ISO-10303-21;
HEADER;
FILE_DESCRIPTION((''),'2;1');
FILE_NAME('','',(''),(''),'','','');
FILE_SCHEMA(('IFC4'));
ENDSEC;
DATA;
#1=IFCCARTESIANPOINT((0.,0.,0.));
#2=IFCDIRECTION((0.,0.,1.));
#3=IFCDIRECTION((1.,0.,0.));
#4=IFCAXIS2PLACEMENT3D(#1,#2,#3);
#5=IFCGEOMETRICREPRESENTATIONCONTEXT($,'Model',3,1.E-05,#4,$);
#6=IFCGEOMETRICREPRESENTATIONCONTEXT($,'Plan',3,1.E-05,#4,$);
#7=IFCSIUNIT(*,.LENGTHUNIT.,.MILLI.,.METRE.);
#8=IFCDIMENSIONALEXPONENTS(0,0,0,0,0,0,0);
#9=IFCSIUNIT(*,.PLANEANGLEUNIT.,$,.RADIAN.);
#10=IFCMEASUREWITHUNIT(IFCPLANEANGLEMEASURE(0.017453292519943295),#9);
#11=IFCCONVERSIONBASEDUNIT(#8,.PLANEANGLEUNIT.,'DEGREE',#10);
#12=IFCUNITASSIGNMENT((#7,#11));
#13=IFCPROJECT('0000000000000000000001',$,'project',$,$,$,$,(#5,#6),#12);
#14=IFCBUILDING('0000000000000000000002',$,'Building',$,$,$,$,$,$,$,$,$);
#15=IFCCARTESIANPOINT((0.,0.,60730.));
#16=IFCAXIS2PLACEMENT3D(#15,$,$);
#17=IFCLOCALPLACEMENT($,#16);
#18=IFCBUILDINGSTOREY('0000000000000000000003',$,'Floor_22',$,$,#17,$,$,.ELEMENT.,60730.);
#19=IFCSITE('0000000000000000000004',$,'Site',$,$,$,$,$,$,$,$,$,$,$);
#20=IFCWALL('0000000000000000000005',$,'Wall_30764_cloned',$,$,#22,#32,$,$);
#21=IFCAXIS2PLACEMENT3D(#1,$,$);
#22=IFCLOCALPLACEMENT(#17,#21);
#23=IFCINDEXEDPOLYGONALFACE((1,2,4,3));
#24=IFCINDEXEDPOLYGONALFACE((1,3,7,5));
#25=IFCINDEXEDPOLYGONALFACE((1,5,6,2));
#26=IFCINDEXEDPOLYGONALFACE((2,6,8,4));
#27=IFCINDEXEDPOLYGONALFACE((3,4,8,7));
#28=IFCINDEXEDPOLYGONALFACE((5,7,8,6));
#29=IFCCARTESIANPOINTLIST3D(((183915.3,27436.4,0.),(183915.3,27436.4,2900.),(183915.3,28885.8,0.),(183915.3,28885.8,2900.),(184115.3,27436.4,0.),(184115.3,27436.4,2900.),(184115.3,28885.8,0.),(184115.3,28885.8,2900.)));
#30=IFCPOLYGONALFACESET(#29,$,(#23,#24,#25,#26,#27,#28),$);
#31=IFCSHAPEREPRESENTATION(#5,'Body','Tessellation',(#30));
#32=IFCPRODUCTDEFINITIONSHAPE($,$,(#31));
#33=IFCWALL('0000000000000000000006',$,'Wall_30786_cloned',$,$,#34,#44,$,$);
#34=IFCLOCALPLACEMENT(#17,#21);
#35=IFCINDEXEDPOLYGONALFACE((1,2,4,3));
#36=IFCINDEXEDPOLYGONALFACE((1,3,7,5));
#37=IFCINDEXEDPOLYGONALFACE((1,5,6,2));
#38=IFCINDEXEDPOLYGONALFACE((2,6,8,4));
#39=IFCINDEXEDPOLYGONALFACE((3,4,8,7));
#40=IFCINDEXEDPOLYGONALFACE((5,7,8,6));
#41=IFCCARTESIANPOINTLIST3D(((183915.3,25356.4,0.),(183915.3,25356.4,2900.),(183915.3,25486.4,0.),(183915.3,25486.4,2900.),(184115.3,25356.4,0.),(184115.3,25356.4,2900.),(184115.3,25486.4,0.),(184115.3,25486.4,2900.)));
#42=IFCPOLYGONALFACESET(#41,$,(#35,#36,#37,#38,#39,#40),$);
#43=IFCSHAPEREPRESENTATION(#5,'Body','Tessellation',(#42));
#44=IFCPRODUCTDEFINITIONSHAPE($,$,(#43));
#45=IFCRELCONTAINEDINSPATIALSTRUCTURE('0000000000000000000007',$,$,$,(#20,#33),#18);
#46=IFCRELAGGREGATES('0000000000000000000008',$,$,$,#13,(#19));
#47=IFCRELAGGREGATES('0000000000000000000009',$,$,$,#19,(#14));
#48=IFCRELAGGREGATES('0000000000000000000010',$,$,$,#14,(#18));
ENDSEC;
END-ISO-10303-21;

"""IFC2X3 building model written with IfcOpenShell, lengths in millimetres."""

from ifc_helpers import new_model, entity, si_unit, converted_unit, frame, origin_with_axes, origin_2d, place, context, project, spatial, rectangle, extrude, source, transform, mapped, element, save


model = new_model("IFC2X3")

# Units and contexts
model_context = context("Model", 3, precision=1e-05, world=origin_with_axes())
plan_context = context("Plan", 3, precision=1e-05, world=origin_with_axes())
ifc_project = project(units=[si_unit("LENGTHUNIT", "METRE", prefix="MILLI"), converted_unit("PLANEANGLEUNIT", "DEGREE", entity("IfcPlaneAngleMeasure", 0.017453292519943295), si_unit("PLANEANGLEUNIT", "RADIAN"), dimensions=[0, 0, 0, 0, 0, 0, 0])], contexts=[model_context, plan_context])

# Site, building, storey
site = spatial("IfcSite", under=ifc_project, Name="Site")
building = spatial("IfcBuilding", under=site, Name="Building")
storey_placement = place(None, frame((0.0, 0.0, 60730.0)))
storey = spatial("IfcBuildingStorey", under=building, at=storey_placement, Name="Floor_22", CompositionType="ELEMENT", Elevation=60730.0)

# Walls
shared_shape_1 = source(origin_with_axes(), model_context, "Body", "SweptSolid", [
    extrude(rectangle(XDim=1449.4, YDim=200.0, at=origin_2d()), origin_with_axes(), (0.0, 0.0, 1.0), 2900.0),
])
wall_1_placement = place(storey_placement, frame((184015.3, 28161.1, 0.0), z_axis=(0.0, 0.0, 1.0), x_axis=(0.0, 1449.4128, 0.0)))
element("IfcWall", 1, at=wall_1_placement, inside=storey, Name="Wall_30764_cloned", context=model_context, shape_type="MappedRepresentation", body=[
    mapped(shared_shape_1, transform((0.0, 0.0, 0.0), x_axis=(1.0, 0.0, 0.0), y_axis=(0.0, 1.0, 0.0), z_axis=(0.0, 0.0, 1.0), scale=1.0)),
])
shared_shape_2 = source(origin_with_axes(), model_context, "Body", "SweptSolid", [
    extrude(rectangle(XDim=130.0, YDim=200.0, at=origin_2d()), origin_with_axes(), (0.0, 0.0, 1.0), 2900.0),
])
wall_2_placement = place(storey_placement, frame((184015.3, 25421.4, 0.0), z_axis=(0.0, 0.0, 1.0), x_axis=(0.0, 130.000004, 0.0)))
element("IfcWall", 2, at=wall_2_placement, inside=storey, Name="Wall_30786_cloned", context=model_context, shape_type="MappedRepresentation", body=[
    mapped(shared_shape_2, transform((0.0, 0.0, 0.0), x_axis=(1.0, 0.0, 0.0), y_axis=(0.0, 1.0, 0.0), z_axis=(0.0, 0.0, 1.0), scale=1.0)),
])

save(model, "model.ifc")
